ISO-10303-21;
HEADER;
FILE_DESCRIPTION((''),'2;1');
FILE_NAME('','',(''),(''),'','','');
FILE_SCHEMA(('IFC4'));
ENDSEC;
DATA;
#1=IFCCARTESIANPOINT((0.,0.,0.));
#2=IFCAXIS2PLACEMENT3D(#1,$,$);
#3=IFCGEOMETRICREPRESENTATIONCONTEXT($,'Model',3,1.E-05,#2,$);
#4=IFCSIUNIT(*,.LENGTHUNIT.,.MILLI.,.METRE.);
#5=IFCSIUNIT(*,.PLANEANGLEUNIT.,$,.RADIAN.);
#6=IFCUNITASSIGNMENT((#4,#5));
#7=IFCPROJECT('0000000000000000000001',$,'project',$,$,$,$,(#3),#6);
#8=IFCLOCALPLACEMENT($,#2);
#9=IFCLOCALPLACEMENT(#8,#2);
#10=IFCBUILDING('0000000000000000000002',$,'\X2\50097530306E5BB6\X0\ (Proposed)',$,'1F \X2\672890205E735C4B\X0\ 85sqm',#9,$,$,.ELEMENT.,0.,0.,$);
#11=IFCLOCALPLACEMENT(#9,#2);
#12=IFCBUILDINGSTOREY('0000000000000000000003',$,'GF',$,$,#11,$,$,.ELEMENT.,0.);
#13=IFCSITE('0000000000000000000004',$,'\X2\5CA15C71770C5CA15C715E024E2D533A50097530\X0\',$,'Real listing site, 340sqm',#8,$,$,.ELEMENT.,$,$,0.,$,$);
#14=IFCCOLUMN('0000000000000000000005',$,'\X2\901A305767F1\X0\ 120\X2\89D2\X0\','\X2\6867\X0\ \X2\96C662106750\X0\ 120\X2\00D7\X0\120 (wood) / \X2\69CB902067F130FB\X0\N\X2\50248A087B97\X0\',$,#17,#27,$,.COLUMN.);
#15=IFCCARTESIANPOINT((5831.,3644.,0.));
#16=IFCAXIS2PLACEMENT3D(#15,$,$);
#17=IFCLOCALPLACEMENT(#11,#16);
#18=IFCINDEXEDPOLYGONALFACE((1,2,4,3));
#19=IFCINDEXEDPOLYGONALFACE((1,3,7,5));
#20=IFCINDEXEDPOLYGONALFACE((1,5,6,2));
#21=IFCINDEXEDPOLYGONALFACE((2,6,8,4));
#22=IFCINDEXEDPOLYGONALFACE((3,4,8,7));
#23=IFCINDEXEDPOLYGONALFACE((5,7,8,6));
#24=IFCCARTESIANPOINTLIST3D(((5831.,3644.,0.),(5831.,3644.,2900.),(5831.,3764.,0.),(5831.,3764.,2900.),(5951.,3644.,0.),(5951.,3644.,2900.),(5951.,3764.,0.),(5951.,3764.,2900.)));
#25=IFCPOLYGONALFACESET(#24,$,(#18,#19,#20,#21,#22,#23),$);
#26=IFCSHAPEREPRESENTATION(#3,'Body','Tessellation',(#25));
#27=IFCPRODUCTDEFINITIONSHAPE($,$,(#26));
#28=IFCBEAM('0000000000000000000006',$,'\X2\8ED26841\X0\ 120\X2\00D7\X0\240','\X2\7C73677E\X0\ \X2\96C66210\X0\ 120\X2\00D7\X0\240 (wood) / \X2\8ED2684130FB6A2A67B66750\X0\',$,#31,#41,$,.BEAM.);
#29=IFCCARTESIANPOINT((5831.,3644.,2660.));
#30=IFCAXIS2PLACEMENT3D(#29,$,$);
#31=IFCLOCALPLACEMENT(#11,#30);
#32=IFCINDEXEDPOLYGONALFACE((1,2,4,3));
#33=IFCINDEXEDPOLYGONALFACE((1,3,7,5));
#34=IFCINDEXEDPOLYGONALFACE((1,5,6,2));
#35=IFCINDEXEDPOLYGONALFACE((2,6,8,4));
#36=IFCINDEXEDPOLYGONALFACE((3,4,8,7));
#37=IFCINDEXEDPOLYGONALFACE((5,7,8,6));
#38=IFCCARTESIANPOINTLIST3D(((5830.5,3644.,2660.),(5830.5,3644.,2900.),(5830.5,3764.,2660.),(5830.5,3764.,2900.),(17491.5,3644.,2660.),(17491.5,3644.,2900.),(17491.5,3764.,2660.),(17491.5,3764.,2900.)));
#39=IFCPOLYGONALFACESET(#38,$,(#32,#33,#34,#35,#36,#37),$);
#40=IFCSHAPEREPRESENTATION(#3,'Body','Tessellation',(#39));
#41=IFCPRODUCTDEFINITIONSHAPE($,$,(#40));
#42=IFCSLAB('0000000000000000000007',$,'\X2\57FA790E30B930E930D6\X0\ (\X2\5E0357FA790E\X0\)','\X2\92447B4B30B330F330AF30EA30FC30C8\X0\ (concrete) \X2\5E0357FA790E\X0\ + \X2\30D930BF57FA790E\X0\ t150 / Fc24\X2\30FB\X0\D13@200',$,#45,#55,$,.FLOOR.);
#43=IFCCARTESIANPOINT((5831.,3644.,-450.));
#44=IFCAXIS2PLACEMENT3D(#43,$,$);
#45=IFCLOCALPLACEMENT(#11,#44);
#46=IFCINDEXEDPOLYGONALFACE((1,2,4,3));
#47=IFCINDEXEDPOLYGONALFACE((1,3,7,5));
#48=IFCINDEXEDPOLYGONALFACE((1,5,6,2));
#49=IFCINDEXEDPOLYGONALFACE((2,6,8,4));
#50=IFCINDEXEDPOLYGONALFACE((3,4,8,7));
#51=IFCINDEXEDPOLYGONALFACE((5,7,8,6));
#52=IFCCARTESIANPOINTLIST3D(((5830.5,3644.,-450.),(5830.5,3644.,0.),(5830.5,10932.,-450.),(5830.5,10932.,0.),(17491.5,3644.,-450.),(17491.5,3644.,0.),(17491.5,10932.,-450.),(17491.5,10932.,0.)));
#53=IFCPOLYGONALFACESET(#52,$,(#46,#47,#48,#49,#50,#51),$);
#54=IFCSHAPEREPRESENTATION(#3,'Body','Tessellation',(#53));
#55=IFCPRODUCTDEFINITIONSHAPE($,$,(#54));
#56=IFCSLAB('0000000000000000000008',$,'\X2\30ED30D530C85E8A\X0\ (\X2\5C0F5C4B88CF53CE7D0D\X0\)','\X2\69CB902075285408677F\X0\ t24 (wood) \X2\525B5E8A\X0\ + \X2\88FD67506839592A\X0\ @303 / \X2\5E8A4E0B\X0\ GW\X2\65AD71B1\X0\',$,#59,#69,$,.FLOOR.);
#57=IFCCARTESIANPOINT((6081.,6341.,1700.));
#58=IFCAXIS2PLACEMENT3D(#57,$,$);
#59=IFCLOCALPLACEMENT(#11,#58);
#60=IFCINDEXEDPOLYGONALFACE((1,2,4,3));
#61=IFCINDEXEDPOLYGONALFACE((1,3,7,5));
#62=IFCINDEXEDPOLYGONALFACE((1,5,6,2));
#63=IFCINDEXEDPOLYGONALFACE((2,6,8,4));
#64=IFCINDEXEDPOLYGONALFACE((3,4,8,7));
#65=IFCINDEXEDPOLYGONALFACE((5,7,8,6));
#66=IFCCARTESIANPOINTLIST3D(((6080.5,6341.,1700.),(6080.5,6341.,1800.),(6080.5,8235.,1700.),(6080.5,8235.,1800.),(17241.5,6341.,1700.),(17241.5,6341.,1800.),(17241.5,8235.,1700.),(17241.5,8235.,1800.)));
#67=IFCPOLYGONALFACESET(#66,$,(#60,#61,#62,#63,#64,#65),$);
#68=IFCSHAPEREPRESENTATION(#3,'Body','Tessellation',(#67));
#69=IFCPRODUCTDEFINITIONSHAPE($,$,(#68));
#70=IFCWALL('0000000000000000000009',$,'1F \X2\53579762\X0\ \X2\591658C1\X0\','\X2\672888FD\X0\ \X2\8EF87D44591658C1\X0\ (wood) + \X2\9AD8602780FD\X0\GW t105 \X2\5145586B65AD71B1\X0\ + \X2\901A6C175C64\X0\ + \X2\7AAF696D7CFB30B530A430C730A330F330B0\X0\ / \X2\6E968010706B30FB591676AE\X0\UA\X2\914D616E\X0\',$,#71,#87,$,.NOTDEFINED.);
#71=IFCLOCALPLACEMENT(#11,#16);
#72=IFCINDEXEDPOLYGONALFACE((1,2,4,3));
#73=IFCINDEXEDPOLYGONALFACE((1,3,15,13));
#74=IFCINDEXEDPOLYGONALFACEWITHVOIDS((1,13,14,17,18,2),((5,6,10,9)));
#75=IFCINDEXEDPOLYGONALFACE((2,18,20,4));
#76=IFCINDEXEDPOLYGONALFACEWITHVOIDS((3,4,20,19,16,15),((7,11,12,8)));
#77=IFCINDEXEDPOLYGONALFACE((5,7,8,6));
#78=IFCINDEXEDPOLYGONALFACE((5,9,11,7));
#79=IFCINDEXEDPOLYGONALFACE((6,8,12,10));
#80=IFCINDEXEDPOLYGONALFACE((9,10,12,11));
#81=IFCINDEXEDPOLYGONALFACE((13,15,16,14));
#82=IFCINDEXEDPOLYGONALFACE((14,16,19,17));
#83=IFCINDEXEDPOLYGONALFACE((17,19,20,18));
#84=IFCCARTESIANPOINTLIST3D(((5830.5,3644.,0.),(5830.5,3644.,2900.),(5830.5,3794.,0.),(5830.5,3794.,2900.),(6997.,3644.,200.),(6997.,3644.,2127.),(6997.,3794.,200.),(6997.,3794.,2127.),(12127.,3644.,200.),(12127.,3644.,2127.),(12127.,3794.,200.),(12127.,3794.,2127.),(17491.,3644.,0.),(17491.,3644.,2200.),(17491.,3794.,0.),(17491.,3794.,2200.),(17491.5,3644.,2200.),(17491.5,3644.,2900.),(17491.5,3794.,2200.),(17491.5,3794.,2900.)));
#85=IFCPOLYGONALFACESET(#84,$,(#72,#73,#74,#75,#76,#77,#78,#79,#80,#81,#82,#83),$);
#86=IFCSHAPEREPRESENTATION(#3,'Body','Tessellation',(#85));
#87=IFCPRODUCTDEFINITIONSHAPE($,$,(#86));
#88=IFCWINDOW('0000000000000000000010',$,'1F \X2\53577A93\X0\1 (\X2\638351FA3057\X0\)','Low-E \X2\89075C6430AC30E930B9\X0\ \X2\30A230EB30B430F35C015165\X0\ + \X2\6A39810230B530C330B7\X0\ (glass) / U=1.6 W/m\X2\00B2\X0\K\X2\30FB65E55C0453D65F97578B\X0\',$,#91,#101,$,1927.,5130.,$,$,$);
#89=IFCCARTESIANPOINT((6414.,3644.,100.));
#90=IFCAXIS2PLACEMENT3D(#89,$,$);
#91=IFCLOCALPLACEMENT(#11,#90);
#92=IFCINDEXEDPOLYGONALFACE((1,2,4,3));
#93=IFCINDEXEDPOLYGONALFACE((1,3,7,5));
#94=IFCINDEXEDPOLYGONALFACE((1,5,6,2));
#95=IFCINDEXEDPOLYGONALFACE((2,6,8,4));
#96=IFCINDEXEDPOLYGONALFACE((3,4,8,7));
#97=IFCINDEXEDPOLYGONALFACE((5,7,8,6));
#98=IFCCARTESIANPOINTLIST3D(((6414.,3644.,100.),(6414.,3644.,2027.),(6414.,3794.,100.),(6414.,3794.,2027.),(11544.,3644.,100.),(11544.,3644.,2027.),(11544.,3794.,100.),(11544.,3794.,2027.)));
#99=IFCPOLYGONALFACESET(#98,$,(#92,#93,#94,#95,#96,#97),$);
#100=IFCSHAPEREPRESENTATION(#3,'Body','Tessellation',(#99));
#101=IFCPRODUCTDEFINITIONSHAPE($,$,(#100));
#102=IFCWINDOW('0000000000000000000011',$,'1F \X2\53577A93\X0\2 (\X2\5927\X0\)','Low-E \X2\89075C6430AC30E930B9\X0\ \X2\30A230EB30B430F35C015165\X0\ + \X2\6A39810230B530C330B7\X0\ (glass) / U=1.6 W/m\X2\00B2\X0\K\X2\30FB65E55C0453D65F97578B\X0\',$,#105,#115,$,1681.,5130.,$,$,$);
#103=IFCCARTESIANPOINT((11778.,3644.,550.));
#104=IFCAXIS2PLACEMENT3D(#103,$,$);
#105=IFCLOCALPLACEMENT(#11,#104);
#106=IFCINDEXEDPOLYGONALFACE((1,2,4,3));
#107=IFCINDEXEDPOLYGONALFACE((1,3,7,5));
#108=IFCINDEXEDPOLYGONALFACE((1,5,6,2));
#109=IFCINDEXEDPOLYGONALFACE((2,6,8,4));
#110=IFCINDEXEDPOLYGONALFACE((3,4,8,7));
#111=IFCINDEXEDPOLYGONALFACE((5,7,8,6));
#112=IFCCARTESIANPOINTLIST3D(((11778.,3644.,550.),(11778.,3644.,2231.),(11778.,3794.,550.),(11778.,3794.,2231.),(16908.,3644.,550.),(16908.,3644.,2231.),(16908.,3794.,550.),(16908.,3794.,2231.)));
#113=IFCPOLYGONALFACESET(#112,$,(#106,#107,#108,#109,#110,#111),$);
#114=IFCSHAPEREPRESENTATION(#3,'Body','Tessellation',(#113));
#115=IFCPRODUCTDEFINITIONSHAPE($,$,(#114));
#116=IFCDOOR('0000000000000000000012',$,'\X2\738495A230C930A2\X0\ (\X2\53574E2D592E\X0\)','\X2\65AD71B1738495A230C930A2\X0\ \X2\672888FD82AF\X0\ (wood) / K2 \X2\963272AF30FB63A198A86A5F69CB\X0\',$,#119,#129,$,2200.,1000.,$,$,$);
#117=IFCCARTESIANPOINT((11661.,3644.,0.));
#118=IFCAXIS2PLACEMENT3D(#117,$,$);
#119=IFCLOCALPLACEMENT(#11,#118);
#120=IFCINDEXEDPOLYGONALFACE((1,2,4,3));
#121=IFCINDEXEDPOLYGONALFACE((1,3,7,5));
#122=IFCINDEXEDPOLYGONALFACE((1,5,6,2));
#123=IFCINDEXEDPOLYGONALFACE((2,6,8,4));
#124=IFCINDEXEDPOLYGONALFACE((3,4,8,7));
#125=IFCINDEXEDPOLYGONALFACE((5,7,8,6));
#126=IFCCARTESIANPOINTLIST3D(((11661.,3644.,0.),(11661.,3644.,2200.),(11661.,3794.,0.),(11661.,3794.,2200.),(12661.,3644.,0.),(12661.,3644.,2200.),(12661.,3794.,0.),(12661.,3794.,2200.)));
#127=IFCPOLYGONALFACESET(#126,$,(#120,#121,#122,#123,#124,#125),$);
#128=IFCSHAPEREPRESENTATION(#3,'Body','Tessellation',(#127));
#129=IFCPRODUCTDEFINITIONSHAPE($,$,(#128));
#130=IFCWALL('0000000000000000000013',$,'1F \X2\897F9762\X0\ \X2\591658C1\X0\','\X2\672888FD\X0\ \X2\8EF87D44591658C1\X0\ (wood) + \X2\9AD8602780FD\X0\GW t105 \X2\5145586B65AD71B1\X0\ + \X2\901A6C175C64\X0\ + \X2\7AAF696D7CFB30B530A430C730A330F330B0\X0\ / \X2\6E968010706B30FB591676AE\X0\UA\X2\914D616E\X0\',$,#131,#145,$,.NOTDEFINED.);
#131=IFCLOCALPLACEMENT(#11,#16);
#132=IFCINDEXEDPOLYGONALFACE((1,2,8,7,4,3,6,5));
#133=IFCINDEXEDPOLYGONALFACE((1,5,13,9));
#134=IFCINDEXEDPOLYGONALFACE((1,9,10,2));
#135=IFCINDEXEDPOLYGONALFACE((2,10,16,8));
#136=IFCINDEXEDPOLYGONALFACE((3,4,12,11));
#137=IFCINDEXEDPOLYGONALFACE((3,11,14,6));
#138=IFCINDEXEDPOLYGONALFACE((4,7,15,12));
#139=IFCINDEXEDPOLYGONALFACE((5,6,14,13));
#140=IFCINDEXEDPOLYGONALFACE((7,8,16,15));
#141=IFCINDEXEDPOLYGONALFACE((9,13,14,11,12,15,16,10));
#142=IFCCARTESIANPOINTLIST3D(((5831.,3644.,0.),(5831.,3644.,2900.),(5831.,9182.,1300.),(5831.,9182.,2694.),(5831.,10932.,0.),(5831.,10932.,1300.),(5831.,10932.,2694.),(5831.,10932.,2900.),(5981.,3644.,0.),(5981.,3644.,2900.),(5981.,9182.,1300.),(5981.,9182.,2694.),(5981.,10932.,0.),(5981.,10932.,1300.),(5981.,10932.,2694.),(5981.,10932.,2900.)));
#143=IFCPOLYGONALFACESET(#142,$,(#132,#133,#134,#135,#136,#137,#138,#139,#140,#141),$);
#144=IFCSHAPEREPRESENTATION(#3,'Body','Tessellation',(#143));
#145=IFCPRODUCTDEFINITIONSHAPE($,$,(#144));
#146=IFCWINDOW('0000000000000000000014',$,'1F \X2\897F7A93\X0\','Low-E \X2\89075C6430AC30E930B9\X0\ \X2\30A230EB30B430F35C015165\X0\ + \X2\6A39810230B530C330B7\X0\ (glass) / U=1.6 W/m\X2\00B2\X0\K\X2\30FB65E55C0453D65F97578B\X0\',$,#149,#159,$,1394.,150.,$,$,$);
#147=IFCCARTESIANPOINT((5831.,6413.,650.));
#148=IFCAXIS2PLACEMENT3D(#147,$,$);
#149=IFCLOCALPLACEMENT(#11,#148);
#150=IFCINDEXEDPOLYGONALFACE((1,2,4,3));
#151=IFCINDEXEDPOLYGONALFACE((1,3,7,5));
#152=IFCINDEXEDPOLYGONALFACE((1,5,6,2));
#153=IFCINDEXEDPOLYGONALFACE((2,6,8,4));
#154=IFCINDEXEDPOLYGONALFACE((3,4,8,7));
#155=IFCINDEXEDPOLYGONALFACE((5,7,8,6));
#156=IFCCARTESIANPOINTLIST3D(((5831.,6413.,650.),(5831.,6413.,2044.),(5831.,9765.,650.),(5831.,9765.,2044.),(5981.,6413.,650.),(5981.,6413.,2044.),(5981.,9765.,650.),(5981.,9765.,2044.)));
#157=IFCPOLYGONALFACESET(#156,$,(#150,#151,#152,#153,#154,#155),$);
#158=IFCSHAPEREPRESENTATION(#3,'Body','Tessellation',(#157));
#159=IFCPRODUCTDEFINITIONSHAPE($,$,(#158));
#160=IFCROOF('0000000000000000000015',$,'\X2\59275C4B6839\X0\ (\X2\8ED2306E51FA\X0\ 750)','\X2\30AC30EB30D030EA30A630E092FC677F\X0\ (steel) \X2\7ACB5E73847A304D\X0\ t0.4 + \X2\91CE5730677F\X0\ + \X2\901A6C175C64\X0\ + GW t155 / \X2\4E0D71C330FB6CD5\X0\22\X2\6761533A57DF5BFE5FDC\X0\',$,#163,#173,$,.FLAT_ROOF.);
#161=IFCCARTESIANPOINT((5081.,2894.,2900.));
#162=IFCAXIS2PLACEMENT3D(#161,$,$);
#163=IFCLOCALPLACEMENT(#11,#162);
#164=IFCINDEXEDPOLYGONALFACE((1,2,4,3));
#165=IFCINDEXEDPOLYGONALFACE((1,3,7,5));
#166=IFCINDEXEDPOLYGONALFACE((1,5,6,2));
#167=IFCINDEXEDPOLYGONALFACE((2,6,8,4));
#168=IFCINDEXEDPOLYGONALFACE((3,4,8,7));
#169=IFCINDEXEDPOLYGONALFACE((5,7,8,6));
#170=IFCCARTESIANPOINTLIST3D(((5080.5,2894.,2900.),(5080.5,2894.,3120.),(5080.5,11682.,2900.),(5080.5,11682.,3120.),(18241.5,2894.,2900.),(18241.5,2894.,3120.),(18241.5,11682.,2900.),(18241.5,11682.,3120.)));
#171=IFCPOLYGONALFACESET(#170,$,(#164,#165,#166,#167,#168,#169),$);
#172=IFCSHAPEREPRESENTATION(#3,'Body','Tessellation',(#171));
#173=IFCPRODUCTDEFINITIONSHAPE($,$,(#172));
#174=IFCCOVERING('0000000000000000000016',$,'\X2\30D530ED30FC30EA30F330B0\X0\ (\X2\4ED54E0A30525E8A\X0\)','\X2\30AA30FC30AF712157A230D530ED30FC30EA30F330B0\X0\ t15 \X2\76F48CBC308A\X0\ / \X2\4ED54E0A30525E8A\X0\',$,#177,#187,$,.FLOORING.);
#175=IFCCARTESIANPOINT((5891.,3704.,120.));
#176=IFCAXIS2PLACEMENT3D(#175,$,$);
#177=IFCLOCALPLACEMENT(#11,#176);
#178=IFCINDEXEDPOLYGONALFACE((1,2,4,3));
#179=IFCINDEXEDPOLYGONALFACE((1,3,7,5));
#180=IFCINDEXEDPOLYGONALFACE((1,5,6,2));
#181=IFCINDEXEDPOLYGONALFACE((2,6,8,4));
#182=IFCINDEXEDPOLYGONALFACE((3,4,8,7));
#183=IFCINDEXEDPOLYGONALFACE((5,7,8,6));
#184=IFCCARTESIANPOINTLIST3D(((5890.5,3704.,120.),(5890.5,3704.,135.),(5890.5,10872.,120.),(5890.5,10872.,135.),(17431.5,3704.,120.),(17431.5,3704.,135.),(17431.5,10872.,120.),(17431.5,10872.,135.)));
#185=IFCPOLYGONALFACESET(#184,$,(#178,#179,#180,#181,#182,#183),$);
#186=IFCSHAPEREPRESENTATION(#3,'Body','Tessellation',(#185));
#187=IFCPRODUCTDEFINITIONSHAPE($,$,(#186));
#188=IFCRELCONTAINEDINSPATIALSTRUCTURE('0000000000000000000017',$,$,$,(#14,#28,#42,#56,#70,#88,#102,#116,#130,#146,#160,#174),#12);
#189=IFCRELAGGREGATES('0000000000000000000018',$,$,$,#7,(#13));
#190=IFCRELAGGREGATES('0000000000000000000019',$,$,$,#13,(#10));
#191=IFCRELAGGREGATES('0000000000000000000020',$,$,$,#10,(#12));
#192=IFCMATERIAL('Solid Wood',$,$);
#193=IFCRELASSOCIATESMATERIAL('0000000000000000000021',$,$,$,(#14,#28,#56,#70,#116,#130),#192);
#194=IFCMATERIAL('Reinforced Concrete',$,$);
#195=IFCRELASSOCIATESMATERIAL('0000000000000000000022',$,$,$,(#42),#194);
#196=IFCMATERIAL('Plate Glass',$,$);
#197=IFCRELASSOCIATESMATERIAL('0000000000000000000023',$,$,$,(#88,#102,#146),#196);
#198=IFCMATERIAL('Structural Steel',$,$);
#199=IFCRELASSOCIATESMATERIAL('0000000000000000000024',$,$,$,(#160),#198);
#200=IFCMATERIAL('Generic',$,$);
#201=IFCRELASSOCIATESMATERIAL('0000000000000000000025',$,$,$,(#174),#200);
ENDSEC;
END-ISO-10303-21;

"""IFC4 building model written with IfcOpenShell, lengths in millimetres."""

from ifc_helpers import new_model, si_unit, frame, frame_2d, origin, place, context, project, spatial, rectangle, extrude, material, element, fill, save


model = new_model("IFC4")

# Units and contexts
model_context = context("Model", 3, precision=1e-05, world=origin())
ifc_project = project(units=[si_unit("LENGTHUNIT", "METRE", prefix="MILLI"), si_unit("PLANEANGLEUNIT", "RADIAN")], contexts=[model_context])

# Site, building, storey
site_placement = place(None, origin())
site = spatial("IfcSite", under=ifc_project, at=site_placement, Name="岡山県岡山市中区倉田", ObjectType="Real listing site, 340sqm", CompositionType="ELEMENT", RefElevation=0.0)
building_placement = place(site_placement, origin())
building = spatial("IfcBuilding", under=site, at=building_placement, Name="倉田の家 (Proposed)", ObjectType="1F 木造平屋 85sqm", CompositionType="ELEMENT", ElevationOfRefHeight=0.0, ElevationOfTerrain=0.0)
storey_placement = place(building_placement, origin())
storey = spatial("IfcBuildingStorey", under=building, at=storey_placement, Name="GF", CompositionType="ELEMENT", Elevation=0.0)

# Column
ifc_material_1 = material(Name="Solid Wood")
column_1_placement = place(storey_placement, frame((5831.0, 3644.0, 0.0)))
element("IfcColumn", 1, at=column_1_placement, inside=storey, material=ifc_material_1, Name="通し柱 120角", Description="桧 集成材 120×120 (wood) / 構造柱・N値計算", PredefinedType="COLUMN", context=model_context, shape_type="SweptSolid", body=[
    extrude(rectangle(XDim=120.0, YDim=120.0, at=frame_2d((60.0, 60.0))), frame((5831.0, 3644.0, 0.0)), (0.0, 0.0, 1.0), 2900.0),
])

# Beam
beam_1_placement = place(storey_placement, frame((5831.0, 3644.0, 2660.0)))
element("IfcBeam", 2, at=beam_1_placement, inside=storey, material=ifc_material_1, Name="軒桁 120×240", Description="米松 集成 120×240 (wood) / 軒桁・横架材", PredefinedType="BEAM", context=model_context, shape_type="SweptSolid", body=[
    extrude(rectangle(XDim=11661.0, YDim=120.0, at=frame_2d((5830.0, 60.0))), frame((5831.0, 3644.0, 2660.0)), (0.0, 0.0, 1.0), 240.0),
])

# Slabs
ifc_material_2 = material(Name="Reinforced Concrete")
slab_1_placement = place(storey_placement, frame((5831.0, 3644.0, -450.0)))
element("IfcSlab", 3, at=slab_1_placement, inside=storey, material=ifc_material_2, Name="基礎スラブ (布基礎)", Description="鉄筋コンクリート (concrete) 布基礎 + ベタ基礎 t150 / Fc24・D13@200", PredefinedType="FLOOR", context=model_context, shape_type="SweptSolid", body=[
    extrude(rectangle(XDim=11661.0, YDim=7288.0, at=frame_2d((5830.0, 3644.0))), frame((5831.0, 3644.0, -450.0)), (0.0, 0.0, 1.0), 450.0),
])
slab_2_placement = place(storey_placement, frame((6081.0, 6341.0, 1700.0)))
element("IfcSlab", 4, at=slab_2_placement, inside=storey, material=ifc_material_1, Name="ロフト床 (小屋裏収納)", Description="構造用合板 t24 (wood) 剛床 + 製材根太 @303 / 床下 GW断熱", PredefinedType="FLOOR", context=model_context, shape_type="SweptSolid", body=[
    extrude(rectangle(XDim=11161.0, YDim=1894.0, at=frame_2d((5580.0, 947.0))), frame((6081.0, 6341.0, 1700.0)), (0.0, 0.0, 1.0), 100.0),
])

# Wall, openings, windows, door
wall_1_placement = place(storey_placement, frame((5831.0, 3644.0, 0.0)))
wall_1 = element("IfcWall", 5, at=wall_1_placement, inside=storey, material=ifc_material_1, Name="1F 南面 外壁", Description="木製 軸組外壁 (wood) + 高性能GW t105 充填断熱 + 通気層 + 窯業系サイディング / 準耐火・外皮UA配慮", PredefinedType="NOTDEFINED", context=model_context, shape_type="SweptSolid", body=[
    extrude(rectangle(XDim=11661.0, YDim=150.0, at=frame_2d((5830.0, 75.0))), frame((5831.0, 3644.0, 0.0)), (0.0, 0.0, 1.0), 2900.0),
])
opening_1_placement = place(storey_placement, frame((6414.0, 3644.0, 100.0)))
opening_1 = element("IfcOpeningElement", 6, at=opening_1_placement, cuts=wall_1, PredefinedType="NOTDEFINED", context=model_context, shape_type="SweptSolid", body=[
    extrude(rectangle(XDim=5130.0, YDim=150.0, at=frame_2d((2565.0, 75.0))), frame((6414.0, 3644.0, 100.0)), (0.0, 0.0, 1.0), 1927.0),
])
opening_2_placement = place(storey_placement, frame((11778.0, 3644.0, 550.0)))
opening_2 = element("IfcOpeningElement", 7, at=opening_2_placement, cuts=wall_1, PredefinedType="NOTDEFINED", context=model_context, shape_type="SweptSolid", body=[
    extrude(rectangle(XDim=5130.0, YDim=150.0, at=frame_2d((2565.0, 75.0))), frame((11778.0, 3644.0, 550.0)), (0.0, 0.0, 1.0), 1681.0),
])
opening_3_placement = place(storey_placement, frame((11661.0, 3644.0, 0.0)))
opening_3 = element("IfcOpeningElement", 8, at=opening_3_placement, cuts=wall_1, PredefinedType="NOTDEFINED", context=model_context, shape_type="SweptSolid", body=[
    extrude(rectangle(XDim=1000.0, YDim=150.0, at=frame_2d((500.0, 75.0))), frame((11661.0, 3644.0, 0.0)), (0.0, 0.0, 1.0), 2200.0),
])
ifc_material_3 = material(Name="Plate Glass")
window_1_placement = place(storey_placement, frame((6414.0, 3644.0, 100.0)))
window_1 = element("IfcWindow", 9, at=window_1_placement, inside=storey, material=ifc_material_3, Name="1F 南窓1 (掃出し)", Description="Low-E 複層ガラス アルゴン封入 + 樹脂サッシ (glass) / U=1.6 W/m²K・日射取得型", OverallHeight=1927.0, OverallWidth=5130.0, context=model_context, shape_type="SweptSolid", body=[
    extrude(rectangle(XDim=5130.0, YDim=150.0, at=frame_2d((2565.0, 75.0))), frame((6414.0, 3644.0, 100.0)), (0.0, 0.0, 1.0), 1927.0),
])
fill(opening_1, window_1)
window_2_placement = place(storey_placement, frame((11778.0, 3644.0, 550.0)))
window_2 = element("IfcWindow", 10, at=window_2_placement, inside=storey, material=ifc_material_3, Name="1F 南窓2 (大)", Description="Low-E 複層ガラス アルゴン封入 + 樹脂サッシ (glass) / U=1.6 W/m²K・日射取得型", OverallHeight=1681.0, OverallWidth=5130.0, context=model_context, shape_type="SweptSolid", body=[
    extrude(rectangle(XDim=5130.0, YDim=150.0, at=frame_2d((2565.0, 75.0))), frame((11778.0, 3644.0, 550.0)), (0.0, 0.0, 1.0), 1681.0),
])
fill(opening_2, window_2)
door_placement = place(storey_placement, frame((11661.0, 3644.0, 0.0)))
door = element("IfcDoor", 11, at=door_placement, inside=storey, material=ifc_material_1, Name="玄関ドア (南中央)", Description="断熱玄関ドア 木製芯 (wood) / K2 防犯・採風機構", OverallHeight=2200.0, OverallWidth=1000.0, context=model_context, shape_type="SweptSolid", body=[
    extrude(rectangle(XDim=1000.0, YDim=150.0, at=frame_2d((500.0, 75.0))), frame((11661.0, 3644.0, 0.0)), (0.0, 0.0, 1.0), 2200.0),
])
fill(opening_3, door)

# Wall, opening, window
wall_2_placement = place(storey_placement, frame((5831.0, 3644.0, 0.0)))
wall_2 = element("IfcWall", 12, at=wall_2_placement, inside=storey, material=ifc_material_1, Name="1F 西面 外壁", Description="木製 軸組外壁 (wood) + 高性能GW t105 充填断熱 + 通気層 + 窯業系サイディング / 準耐火・外皮UA配慮", PredefinedType="NOTDEFINED", context=model_context, shape_type="SweptSolid", body=[
    extrude(rectangle(XDim=150.0, YDim=7288.0, at=frame_2d((75.0, 3644.0))), frame((5831.0, 3644.0, 0.0)), (0.0, 0.0, 1.0), 2900.0),
])
opening_4_placement = place(storey_placement, frame((5831.0, 6413.0, 650.0)))
opening_4 = element("IfcOpeningElement", 13, at=opening_4_placement, cuts=wall_2, PredefinedType="NOTDEFINED", context=model_context, shape_type="SweptSolid", body=[
    extrude(rectangle(XDim=150.0, YDim=3352.0, at=frame_2d((75.0, 1676.0))), frame((5831.0, 6413.0, 650.0)), (0.0, 0.0, 1.0), 1394.0),
])
window_3_placement = place(storey_placement, frame((5831.0, 6413.0, 650.0)))
window_3 = element("IfcWindow", 14, at=window_3_placement, inside=storey, material=ifc_material_3, Name="1F 西窓", Description="Low-E 複層ガラス アルゴン封入 + 樹脂サッシ (glass) / U=1.6 W/m²K・日射取得型", OverallHeight=1394.0, OverallWidth=150.0, context=model_context, shape_type="SweptSolid", body=[
    extrude(rectangle(XDim=150.0, YDim=3352.0, at=frame_2d((75.0, 1676.0))), frame((5831.0, 6413.0, 650.0)), (0.0, 0.0, 1.0), 1394.0),
])
fill(opening_4, window_3)

# Roof
ifc_material_4 = material(Name="Structural Steel")
roof_placement = place(storey_placement, frame((5081.0, 2894.0, 2900.0)))
element("IfcRoof", 15, at=roof_placement, inside=storey, material=ifc_material_4, Name="大屋根 (軒の出 750)", Description="ガルバリウム鋼板 (steel) 立平葺き t0.4 + 野地板 + 通気層 + GW t155 / 不燃・法22条区域対応", PredefinedType="FLAT_ROOF", context=model_context, shape_type="SweptSolid", body=[
    extrude(rectangle(XDim=13161.0, YDim=8788.0, at=frame_2d((6580.0, 4394.0))), frame((5081.0, 2894.0, 2900.0)), (0.0, 0.0, 1.0), 220.0),
])

# Covering
ifc_material_5 = material(Name="Generic")
covering_1_placement = place(storey_placement, frame((5891.0, 3704.0, 120.0)))
element("IfcCovering", 16, at=covering_1_placement, inside=storey, material=ifc_material_5, Name="フローリング (仕上げ床)", Description="オーク無垢フローリング t15 直貼り / 仕上げ床", PredefinedType="FLOORING", context=model_context, shape_type="SweptSolid", body=[
    extrude(rectangle(XDim=11541.0, YDim=7168.0, at=frame_2d((5770.0, 3584.0))), frame((5891.0, 3704.0, 120.0)), (0.0, 0.0, 1.0), 15.0),
])

save(model, "model.ifc")
